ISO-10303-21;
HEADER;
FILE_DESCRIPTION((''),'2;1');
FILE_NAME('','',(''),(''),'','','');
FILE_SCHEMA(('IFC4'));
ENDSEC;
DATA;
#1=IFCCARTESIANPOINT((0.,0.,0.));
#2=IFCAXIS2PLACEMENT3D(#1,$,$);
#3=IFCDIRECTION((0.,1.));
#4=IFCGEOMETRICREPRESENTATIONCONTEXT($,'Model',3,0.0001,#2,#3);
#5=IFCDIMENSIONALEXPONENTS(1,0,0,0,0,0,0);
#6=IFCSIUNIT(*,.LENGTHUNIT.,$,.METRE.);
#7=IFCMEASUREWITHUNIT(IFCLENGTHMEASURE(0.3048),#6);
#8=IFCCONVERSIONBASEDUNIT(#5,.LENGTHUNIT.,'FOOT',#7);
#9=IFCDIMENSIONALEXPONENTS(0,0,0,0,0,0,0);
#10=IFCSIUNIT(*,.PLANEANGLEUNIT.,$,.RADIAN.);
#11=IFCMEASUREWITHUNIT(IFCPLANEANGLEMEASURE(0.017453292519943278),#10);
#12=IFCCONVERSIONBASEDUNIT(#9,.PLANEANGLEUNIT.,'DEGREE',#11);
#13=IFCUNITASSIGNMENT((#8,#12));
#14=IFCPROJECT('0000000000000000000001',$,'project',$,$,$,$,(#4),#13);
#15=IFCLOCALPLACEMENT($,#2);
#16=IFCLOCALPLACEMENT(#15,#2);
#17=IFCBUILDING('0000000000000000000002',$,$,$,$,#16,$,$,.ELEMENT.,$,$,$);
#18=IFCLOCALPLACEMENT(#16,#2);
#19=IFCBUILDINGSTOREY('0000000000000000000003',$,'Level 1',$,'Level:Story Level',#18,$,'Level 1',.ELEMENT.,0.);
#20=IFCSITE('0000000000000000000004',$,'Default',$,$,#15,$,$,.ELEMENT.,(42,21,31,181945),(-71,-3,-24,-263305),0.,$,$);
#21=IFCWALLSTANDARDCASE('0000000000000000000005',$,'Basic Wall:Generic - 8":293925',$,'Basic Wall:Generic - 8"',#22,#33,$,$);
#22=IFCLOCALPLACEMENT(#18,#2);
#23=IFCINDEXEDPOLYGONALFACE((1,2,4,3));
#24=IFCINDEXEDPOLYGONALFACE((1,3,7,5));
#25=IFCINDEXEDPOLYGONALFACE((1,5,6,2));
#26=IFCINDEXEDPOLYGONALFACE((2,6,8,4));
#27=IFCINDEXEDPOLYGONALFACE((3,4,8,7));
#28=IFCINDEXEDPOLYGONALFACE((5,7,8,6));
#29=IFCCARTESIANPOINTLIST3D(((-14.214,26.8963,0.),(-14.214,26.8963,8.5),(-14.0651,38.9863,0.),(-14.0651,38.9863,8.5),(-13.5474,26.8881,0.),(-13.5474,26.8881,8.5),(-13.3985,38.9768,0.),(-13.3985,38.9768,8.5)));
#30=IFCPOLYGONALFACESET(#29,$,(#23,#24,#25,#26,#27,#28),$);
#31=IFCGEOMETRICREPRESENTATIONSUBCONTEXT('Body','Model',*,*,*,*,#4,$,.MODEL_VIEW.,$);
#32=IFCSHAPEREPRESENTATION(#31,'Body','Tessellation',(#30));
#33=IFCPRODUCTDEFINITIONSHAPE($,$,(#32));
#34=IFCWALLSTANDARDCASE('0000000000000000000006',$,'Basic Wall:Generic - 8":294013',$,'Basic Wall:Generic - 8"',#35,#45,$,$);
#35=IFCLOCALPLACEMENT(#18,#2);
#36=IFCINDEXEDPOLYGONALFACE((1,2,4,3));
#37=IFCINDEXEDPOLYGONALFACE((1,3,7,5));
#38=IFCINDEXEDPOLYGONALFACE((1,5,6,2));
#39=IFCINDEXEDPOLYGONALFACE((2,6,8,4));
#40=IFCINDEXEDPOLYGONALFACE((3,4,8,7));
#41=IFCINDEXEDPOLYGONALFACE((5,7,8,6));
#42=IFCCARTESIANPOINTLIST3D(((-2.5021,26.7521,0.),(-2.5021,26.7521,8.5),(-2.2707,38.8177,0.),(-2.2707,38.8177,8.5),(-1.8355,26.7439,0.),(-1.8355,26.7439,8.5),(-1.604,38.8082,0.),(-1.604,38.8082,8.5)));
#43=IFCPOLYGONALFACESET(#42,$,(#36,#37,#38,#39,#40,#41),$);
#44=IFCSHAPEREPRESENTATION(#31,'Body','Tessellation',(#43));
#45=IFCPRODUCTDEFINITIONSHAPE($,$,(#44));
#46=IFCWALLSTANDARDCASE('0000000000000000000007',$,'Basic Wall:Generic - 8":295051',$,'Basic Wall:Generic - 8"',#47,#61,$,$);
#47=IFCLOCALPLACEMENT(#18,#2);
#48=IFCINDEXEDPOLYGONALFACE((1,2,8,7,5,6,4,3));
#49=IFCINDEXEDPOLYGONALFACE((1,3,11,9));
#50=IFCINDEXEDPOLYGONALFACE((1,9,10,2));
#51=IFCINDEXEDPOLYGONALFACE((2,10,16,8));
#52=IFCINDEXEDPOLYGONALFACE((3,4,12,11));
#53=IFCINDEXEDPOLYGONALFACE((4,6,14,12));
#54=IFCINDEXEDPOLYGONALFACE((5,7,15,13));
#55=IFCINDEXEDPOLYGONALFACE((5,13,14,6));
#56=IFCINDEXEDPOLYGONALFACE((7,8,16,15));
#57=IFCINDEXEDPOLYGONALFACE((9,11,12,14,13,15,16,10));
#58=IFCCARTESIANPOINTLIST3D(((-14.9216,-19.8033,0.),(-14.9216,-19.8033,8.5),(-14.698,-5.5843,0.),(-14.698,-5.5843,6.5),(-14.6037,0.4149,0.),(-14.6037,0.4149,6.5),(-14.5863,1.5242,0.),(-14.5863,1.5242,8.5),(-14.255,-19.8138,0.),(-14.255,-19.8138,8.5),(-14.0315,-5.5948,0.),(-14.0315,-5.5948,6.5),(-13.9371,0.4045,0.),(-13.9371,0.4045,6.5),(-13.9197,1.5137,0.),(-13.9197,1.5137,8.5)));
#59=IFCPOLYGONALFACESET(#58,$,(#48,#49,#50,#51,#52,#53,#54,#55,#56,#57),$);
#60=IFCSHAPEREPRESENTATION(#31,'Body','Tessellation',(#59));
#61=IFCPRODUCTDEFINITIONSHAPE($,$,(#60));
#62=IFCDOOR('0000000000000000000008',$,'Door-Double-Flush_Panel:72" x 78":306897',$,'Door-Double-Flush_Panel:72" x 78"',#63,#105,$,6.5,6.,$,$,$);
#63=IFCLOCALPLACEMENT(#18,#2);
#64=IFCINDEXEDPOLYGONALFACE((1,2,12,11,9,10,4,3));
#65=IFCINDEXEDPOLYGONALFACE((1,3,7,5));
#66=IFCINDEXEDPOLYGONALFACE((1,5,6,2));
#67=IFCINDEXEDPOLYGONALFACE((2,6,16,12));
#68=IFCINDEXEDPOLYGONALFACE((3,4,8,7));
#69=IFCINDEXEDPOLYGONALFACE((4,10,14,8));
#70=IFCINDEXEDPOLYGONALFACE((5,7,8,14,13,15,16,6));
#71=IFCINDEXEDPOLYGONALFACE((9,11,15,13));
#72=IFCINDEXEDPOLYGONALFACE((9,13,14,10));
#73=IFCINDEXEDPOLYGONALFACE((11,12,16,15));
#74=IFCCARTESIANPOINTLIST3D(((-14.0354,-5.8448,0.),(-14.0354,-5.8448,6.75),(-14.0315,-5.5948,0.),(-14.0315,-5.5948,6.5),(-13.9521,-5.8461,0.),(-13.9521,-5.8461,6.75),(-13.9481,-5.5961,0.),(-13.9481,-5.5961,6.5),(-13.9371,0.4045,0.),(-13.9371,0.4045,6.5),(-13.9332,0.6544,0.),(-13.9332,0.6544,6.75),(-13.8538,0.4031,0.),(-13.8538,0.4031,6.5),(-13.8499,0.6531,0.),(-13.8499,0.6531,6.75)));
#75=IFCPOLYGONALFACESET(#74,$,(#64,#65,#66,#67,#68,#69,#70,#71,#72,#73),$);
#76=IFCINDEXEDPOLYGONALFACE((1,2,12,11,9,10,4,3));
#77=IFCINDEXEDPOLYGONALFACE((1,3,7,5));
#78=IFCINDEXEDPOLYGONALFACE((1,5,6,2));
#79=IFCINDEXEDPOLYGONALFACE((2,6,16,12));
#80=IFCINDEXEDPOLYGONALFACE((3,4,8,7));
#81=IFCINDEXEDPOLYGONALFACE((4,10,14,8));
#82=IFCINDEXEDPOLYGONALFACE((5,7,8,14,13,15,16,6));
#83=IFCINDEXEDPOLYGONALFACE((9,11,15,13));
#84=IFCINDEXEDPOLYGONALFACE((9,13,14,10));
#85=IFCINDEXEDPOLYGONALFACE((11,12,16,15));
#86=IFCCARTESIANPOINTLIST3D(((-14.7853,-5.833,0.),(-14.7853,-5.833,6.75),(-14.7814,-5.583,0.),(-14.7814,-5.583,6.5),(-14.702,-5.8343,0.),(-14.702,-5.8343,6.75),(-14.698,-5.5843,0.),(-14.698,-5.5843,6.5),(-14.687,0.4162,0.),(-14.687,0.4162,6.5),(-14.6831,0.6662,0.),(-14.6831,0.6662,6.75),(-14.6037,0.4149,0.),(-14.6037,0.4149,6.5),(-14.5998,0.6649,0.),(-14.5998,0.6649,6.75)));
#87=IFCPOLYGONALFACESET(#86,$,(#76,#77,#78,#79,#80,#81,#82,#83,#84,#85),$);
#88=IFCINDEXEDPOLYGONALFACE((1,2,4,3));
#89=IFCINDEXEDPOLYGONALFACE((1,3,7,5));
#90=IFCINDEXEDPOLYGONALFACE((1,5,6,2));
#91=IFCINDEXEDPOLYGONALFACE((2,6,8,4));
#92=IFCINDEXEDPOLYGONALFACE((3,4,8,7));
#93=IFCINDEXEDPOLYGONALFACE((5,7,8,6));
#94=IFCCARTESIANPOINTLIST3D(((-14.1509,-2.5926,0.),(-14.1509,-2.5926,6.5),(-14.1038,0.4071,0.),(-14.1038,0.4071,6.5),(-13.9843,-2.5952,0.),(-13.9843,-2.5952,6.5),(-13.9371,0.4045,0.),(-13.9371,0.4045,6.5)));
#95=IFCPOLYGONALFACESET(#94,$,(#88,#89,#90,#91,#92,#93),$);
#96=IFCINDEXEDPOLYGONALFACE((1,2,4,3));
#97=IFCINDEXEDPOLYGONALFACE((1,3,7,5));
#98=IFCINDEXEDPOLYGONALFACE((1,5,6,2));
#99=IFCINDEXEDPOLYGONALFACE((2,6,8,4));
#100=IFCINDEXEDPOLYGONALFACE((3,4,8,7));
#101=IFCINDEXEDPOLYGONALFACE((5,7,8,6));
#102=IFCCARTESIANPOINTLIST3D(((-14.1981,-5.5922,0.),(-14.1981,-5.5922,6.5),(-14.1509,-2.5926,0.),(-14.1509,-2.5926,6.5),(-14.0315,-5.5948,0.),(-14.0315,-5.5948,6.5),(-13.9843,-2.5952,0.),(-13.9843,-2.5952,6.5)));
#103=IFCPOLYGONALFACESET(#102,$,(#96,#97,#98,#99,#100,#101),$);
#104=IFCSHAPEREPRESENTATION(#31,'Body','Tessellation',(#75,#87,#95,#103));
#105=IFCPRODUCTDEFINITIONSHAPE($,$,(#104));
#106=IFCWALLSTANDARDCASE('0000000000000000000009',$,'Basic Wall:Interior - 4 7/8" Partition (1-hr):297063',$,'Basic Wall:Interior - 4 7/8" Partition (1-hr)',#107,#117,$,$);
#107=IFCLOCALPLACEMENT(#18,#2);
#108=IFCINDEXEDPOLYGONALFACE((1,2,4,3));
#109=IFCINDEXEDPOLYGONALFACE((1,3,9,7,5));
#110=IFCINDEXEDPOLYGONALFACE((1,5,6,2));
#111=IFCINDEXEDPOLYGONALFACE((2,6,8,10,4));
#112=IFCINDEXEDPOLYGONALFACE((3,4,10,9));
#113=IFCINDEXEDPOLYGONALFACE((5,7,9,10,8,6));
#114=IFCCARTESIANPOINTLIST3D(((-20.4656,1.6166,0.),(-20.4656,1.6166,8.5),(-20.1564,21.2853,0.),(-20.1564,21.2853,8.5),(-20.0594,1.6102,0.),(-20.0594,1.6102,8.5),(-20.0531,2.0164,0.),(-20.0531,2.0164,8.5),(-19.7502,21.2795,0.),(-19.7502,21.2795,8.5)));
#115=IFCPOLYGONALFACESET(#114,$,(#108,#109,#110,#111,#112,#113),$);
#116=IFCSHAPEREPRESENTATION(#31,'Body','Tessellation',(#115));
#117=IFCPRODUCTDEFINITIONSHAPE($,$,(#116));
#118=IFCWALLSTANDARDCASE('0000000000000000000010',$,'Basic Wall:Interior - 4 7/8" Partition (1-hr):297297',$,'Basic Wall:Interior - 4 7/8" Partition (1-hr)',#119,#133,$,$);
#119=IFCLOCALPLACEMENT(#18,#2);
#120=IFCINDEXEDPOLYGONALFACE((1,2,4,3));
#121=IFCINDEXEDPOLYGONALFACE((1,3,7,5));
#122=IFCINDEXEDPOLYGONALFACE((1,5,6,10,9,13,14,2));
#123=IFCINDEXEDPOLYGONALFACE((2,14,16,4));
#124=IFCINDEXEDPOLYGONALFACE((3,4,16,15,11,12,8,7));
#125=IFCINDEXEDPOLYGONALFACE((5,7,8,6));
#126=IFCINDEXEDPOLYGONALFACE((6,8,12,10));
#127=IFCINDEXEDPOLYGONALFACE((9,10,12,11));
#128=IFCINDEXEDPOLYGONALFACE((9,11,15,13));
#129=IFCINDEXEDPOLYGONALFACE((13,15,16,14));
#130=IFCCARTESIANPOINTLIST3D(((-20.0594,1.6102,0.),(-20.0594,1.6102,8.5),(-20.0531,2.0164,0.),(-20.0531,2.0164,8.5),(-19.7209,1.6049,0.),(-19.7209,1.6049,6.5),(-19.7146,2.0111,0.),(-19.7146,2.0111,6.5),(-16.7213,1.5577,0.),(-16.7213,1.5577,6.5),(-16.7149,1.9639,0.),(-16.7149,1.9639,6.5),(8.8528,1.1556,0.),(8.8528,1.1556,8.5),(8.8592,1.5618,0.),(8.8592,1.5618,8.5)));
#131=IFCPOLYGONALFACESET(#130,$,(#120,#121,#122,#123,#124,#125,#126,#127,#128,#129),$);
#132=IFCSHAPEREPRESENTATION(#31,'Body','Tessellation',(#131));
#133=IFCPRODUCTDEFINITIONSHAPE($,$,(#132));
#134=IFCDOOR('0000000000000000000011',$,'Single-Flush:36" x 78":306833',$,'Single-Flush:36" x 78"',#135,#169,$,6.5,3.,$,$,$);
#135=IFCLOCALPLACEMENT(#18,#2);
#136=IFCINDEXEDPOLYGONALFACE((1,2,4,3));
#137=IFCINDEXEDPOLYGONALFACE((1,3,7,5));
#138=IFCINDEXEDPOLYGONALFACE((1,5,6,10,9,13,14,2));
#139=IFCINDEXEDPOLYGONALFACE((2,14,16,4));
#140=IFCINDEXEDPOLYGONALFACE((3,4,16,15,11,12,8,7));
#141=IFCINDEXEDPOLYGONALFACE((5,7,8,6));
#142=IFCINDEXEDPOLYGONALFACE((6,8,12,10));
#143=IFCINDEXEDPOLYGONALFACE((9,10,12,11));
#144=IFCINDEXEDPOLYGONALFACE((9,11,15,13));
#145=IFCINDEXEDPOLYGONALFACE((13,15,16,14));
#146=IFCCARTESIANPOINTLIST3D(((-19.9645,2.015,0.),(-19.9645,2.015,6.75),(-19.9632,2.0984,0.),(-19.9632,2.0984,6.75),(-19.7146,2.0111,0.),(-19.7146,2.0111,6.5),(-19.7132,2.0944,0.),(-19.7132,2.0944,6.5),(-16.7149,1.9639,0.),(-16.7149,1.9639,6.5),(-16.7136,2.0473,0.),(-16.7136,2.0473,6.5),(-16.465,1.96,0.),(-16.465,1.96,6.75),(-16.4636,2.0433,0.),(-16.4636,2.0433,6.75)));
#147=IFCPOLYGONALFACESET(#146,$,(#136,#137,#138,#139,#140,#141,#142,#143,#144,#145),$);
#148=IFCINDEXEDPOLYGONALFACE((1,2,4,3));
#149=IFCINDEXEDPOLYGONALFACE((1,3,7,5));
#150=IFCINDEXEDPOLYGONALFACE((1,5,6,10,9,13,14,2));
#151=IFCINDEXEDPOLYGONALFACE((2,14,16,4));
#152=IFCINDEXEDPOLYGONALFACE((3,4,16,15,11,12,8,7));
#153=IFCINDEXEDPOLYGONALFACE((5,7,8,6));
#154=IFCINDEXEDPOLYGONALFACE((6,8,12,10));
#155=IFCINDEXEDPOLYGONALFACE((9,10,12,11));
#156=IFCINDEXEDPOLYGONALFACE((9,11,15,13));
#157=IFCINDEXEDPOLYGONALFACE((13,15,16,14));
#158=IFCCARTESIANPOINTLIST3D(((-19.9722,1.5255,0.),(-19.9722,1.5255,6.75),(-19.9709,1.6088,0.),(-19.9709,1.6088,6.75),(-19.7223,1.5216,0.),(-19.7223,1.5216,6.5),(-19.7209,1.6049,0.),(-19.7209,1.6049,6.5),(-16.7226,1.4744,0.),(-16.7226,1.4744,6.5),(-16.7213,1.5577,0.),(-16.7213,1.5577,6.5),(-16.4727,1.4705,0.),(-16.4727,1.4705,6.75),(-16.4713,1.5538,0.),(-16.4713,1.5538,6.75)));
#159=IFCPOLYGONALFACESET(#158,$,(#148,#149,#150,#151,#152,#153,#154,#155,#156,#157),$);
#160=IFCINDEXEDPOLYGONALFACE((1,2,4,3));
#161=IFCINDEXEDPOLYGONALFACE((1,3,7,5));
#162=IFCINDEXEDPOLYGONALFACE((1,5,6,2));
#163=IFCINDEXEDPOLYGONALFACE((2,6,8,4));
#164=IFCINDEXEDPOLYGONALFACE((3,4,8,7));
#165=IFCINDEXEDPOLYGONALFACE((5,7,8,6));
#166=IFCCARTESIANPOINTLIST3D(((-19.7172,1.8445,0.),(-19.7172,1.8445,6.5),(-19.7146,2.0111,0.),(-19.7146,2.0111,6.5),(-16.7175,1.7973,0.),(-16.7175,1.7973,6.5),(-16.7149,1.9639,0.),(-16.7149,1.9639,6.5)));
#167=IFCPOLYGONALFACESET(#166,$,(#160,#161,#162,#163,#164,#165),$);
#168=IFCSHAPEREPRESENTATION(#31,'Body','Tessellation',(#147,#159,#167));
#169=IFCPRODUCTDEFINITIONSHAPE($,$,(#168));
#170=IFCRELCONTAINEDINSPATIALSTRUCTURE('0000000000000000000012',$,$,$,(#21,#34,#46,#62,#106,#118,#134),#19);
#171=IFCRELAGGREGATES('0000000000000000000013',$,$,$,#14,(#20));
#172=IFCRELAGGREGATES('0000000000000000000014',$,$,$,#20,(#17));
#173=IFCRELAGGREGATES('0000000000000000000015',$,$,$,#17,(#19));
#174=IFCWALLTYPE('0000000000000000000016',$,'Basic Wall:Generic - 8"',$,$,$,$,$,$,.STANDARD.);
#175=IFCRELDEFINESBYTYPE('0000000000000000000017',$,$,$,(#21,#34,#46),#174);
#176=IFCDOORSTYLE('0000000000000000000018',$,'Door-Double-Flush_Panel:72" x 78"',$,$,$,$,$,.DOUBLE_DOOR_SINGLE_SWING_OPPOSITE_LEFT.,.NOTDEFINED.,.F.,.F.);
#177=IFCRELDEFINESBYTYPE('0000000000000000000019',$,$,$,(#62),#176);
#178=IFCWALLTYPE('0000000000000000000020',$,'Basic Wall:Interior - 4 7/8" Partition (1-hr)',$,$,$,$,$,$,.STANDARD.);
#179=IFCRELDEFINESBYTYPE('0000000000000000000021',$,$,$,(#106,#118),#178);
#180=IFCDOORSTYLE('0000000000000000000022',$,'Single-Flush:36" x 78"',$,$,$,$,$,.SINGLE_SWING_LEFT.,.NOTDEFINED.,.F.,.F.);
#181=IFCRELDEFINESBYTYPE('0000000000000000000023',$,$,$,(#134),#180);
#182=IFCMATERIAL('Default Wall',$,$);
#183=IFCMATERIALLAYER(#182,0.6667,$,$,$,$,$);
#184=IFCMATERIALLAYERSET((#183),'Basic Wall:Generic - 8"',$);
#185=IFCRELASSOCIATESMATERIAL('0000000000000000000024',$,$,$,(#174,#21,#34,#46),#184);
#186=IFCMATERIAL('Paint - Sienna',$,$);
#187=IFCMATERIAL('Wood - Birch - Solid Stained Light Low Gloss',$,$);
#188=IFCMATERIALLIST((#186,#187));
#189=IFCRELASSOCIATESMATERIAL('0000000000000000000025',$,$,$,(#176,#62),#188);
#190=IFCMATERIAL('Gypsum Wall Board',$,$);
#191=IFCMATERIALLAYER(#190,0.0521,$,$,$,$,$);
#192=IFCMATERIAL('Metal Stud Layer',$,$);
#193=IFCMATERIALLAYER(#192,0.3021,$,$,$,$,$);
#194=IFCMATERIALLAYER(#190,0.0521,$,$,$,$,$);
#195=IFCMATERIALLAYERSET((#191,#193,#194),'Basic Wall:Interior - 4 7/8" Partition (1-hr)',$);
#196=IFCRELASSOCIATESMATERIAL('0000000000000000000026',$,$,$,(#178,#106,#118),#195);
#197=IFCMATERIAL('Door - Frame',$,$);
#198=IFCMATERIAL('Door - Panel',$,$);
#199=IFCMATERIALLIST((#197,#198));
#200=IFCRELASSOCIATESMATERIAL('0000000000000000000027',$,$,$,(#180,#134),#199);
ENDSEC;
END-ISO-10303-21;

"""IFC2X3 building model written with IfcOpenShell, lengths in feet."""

from ifc_helpers import new_model, entity, si_unit, converted_unit, direction, frame, frame_2d, origin, origin_2d_with_axis, place, context, subcontext, project, spatial, polyline, rectangle, outline, extrude, source, transform, mapped, material, material_list, layer, layer_set, layer_usage, type_object, type_shapes, element, fill, save


model = new_model("IFC2X3")

# Units and contexts
model_context = context("Model", 3, precision=0.0001, world=origin(), true_north=direction((0.0, 1.0)))
body_context = subcontext(model_context, "Body", "Model", "MODEL_VIEW")
ifc_project = project(units=[converted_unit("LENGTHUNIT", "FOOT", entity("IfcLengthMeasure", 0.3048), si_unit("LENGTHUNIT", "METRE"), dimensions=[1, 0, 0, 0, 0, 0, 0]), converted_unit("PLANEANGLEUNIT", "DEGREE", entity("IfcPlaneAngleMeasure", 0.017453292519943278), si_unit("PLANEANGLEUNIT", "RADIAN"), dimensions=[0, 0, 0, 0, 0, 0, 0])], contexts=[model_context])

# Site, building, storey
site_placement = place(None, origin())
site = spatial("IfcSite", under=ifc_project, at=site_placement, Name="Default", CompositionType="ELEMENT", RefLatitude=(42, 21, 31, 181945), RefLongitude=(-71, -3, -24, -263305), RefElevation=0.0)
building_placement = place(site_placement, origin())
building = spatial("IfcBuilding", under=site, at=building_placement, CompositionType="ELEMENT")
storey_placement = place(building_placement, origin())
storey = spatial("IfcBuildingStorey", under=building, at=storey_placement, Name="Level 1", ObjectType="Level:Story Level", LongName="Level 1", CompositionType="ELEMENT", Elevation=0.0)

# Shared definitions
ifc_material_1 = material(Name="Default Wall")
ifc_layer_1 = layer(ifc_material_1, 0.6667)
ifc_layer_set_1 = layer_set([ifc_layer_1], Name="Basic Wall:Generic - 8\"")
wall_type_1 = type_object("IfcWallType", Name="Basic Wall:Generic - 8\"", PredefinedType="STANDARD", material=ifc_layer_set_1)

# Walls
ifc_layer_usage_1 = layer_usage(ifc_layer_set_1, "AXIS2", "NEGATIVE", 0.3333)
wall_1_placement = place(storey_placement, frame((-13.7318, 38.9822, 0.0), z_axis=(0.0, 0.0, 1.0), x_axis=(-0.012316, -0.999924, 0.0)))
element("IfcWallStandardCase", 1, at=wall_1_placement, inside=storey, type_object=wall_type_1, material=ifc_layer_usage_1, Name="Basic Wall:Generic - 8\":293925", ObjectType="Basic Wall:Generic - 8\"", context=body_context, shape_type="SweptSolid", body=[
    extrude(outline(polyline([(12.0909, -0.3333), (12.0909, 0.3333), (0.0013, 0.3333), (0.0, -0.3333), (12.0909, -0.3333)])), origin(), (0.0, 0.0, 1.0), 8.5),
])
ifc_layer_usage_2 = layer_usage(ifc_layer_set_1, "AXIS2", "NEGATIVE", 0.3333)
wall_2_placement = place(storey_placement, frame((-1.9373, 38.8146, 0.0), z_axis=(0.0, 0.0, 1.0), x_axis=(-0.019177, -0.999816, 0.0)))
element("IfcWallStandardCase", 2, at=wall_2_placement, inside=storey, type_object=wall_type_1, material=ifc_layer_usage_2, Name="Basic Wall:Generic - 8\":294013", ObjectType="Basic Wall:Generic - 8\"", context=body_context, shape_type="SweptSolid", body=[
    extrude(outline(polyline([(12.0711, -0.3333), (12.0666, 0.3333), (0.0, 0.3333), (0.0033, -0.3333), (12.0711, -0.3333)])), origin(), (0.0, 0.0, 1.0), 8.5),
])

# Wall, opening, door
ifc_layer_usage_3 = layer_usage(ifc_layer_set_1, "AXIS2", "NEGATIVE", 0.3333)
wall_3_placement = place(storey_placement, frame((-14.253, 1.5189, 0.0), z_axis=(0.0, 0.0, 1.0), x_axis=(-0.015721, -0.999876, 0.0)))
wall_3 = element("IfcWallStandardCase", 3, at=wall_3_placement, inside=storey, type_object=wall_type_1, material=ifc_layer_usage_3, Name="Basic Wall:Generic - 8\":295051", ObjectType="Basic Wall:Generic - 8\"", context=body_context, shape_type="SweptSolid", body=[
    extrude(rectangle(XDim=21.3301, YDim=0.6667, at=frame_2d((10.665, 0.0), x_axis=(-1.0, 0.0))), origin(), (0.0, 0.0, 1.0), 8.5),
])
opening_1_placement = place(wall_3_placement, frame((1.1094, -0.3333, 0.0)))
opening_1 = element("IfcOpeningElement", 4, at=opening_1_placement, cuts=wall_3, ObjectType="Opening", context=body_context, shape_type="SweptSolid", body=[
    extrude(rectangle(XDim=6.5, YDim=6.0, at=frame_2d((3.25, 3.0), x_axis=(1.0, 0.0))), frame((0.0, 0.0, 0.0), z_axis=(0.0, 1.0, 0.0), x_axis=(0.0, 0.0, 1.0)), (0.0, 0.0, 1.0), 0.6667),
])
ifc_material_2 = material(Name="Paint - Sienna")
ifc_material_3 = material(Name="Wood - Birch - Solid Stained Light Low Gloss")
ifc_material_list_1 = material_list([ifc_material_2, ifc_material_3])
door_style_1 = type_object("IfcDoorStyle", Name="Door-Double-Flush_Panel:72\" x 78\"", ConstructionType="NOTDEFINED", OperationType="DOUBLE_DOOR_SINGLE_SWING_OPPOSITE_LEFT", ParameterTakesPrecedence=False, Sizeable=False, material=ifc_material_list_1)
shared_shape_1 = source(origin(), body_context, "Body", "SweptSolid", [
    extrude(outline(polyline([(-3.1875, 3.0), (3.3125, 3.0), (3.3125, 3.25), (-3.4375, 3.25), (-3.4375, -3.25), (3.3125, -3.25), (3.3125, -3.0), (-3.1875, -3.0), (-3.1875, 3.0)])), frame((3.0, 0.6667, 3.3125), z_axis=(0.0, 1.0, 0.0), x_axis=(0.0, 0.0, -1.0)), (0.0, 0.0, 1.0), 0.0833),
    extrude(outline(polyline([(-3.1875, 3.0), (3.3125, 3.0), (3.3125, 3.25), (-3.4375, 3.25), (-3.4375, -3.25), (3.3125, -3.25), (3.3125, -3.0), (-3.1875, -3.0), (-3.1875, 3.0)])), frame((3.0, -0.0833, 3.3125), z_axis=(0.0, 1.0, 0.0), x_axis=(0.0, 0.0, -1.0)), (0.0, 0.0, 1.0), 0.0833),
    extrude(rectangle(XDim=0.1667, YDim=3.0, at=frame_2d((0.0, 0.0), x_axis=(1.0, 0.0))), frame((1.5, 0.5833, 0.0), z_axis=(0.0, 0.0, 1.0), x_axis=(0.0, -1.0, 0.0)), (0.0, 0.0, 1.0), 6.5),
    extrude(rectangle(XDim=0.1667, YDim=3.0, at=frame_2d((0.0, 0.0), x_axis=(1.0, 0.0))), frame((4.5, 0.5833, 0.0), z_axis=(0.0, 0.0, 1.0), x_axis=(0.0, -1.0, 0.0)), (0.0, 0.0, 1.0), 6.5),
])
type_shapes(door_style_1, [shared_shape_1])
door_1_placement = place(opening_1_placement, origin())
door_1 = element("IfcDoor", 5, at=door_1_placement, inside=storey, type_object=door_style_1, material=ifc_material_list_1, Name="Door-Double-Flush_Panel:72\" x 78\":306897", ObjectType="Door-Double-Flush_Panel:72\" x 78\"", OverallHeight=6.5, OverallWidth=6.0, context=body_context, shape_type="MappedRepresentation", body=[
    mapped(shared_shape_1, transform((0.0, 0.0, 0.0), scale=1.0)),
])
fill(opening_1, door_1)

# Wall
ifc_material_4 = material(Name="Gypsum Wall Board")
ifc_layer_2 = layer(ifc_material_4, 0.0521)
ifc_material_5 = material(Name="Metal Stud Layer")
ifc_layer_3 = layer(ifc_material_5, 0.3021)
ifc_layer_4 = layer(ifc_material_4, 0.0521)
ifc_layer_set_2 = layer_set([ifc_layer_2, ifc_layer_3, ifc_layer_4], Name="Basic Wall:Interior - 4 7/8\" Partition (1-hr)")
ifc_layer_usage_4 = layer_usage(ifc_layer_set_2, "AXIS2", "NEGATIVE", 0.2031)
wall_type_2 = type_object("IfcWallType", Name="Basic Wall:Interior - 4 7/8\" Partition (1-hr)", PredefinedType="STANDARD", material=ifc_layer_set_2)
wall_4_placement = place(storey_placement, frame((-19.9533, 21.2827, 0.0), z_axis=(0.0, 0.0, 1.0), x_axis=(-0.015721, -0.999876, 0.0)))
element("IfcWallStandardCase", 6, at=wall_4_placement, inside=storey, type_object=wall_type_2, material=ifc_layer_usage_4, Name="Basic Wall:Interior - 4 7/8\" Partition (1-hr):297063", ObjectType="Basic Wall:Interior - 4 7/8\" Partition (1-hr)", context=body_context, shape_type="SweptSolid", body=[
    extrude(outline(polyline([(19.6717, -0.2031), (19.6717, 0.2031), (19.2655, 0.2031), (0.0, 0.2031), (0.0006, -0.2031), (19.6717, -0.2031)])), origin(), (0.0, 0.0, 1.0), 8.5),
])

# Wall, opening, door
ifc_layer_usage_5 = layer_usage(ifc_layer_set_2, "AXIS2", "NEGATIVE", 0.2031)
wall_5_placement = place(storey_placement, frame((-20.0563, 1.8133, 0.0), z_axis=(0.0, 0.0, 1.0), x_axis=(0.999876, -0.015721, 0.0)))
wall_5 = element("IfcWallStandardCase", 7, at=wall_5_placement, inside=storey, type_object=wall_type_2, material=ifc_layer_usage_5, Name="Basic Wall:Interior - 4 7/8\" Partition (1-hr):297297", ObjectType="Basic Wall:Interior - 4 7/8\" Partition (1-hr)", context=body_context, shape_type="SweptSolid", body=[
    extrude(rectangle(XDim=28.9158, YDim=0.4063, at=frame_2d((14.4579, 0.0), x_axis=(1.0, 0.0))), origin(), (0.0, 0.0, 1.0), 8.5),
])
opening_2_placement = place(wall_5_placement, frame((0.3385, -0.2031, 0.0)))
opening_2 = element("IfcOpeningElement", 8, at=opening_2_placement, cuts=wall_5, ObjectType="Opening", context=body_context, shape_type="SweptSolid", body=[
    extrude(rectangle(XDim=3.0, YDim=6.5, at=frame_2d((3.25, 1.5), x_axis=(0.0, -1.0))), frame((0.0, 0.0, 0.0), z_axis=(0.0, 1.0, 0.0), x_axis=(0.0, 0.0, 1.0)), (0.0, 0.0, 1.0), 0.4062),
])
ifc_material_6 = material(Name="Door - Frame")
ifc_material_7 = material(Name="Door - Panel")
ifc_material_list_2 = material_list([ifc_material_6, ifc_material_7])
door_style_2 = type_object("IfcDoorStyle", Name="Single-Flush:36\" x 78\"", ConstructionType="NOTDEFINED", OperationType="SINGLE_SWING_LEFT", ParameterTakesPrecedence=False, Sizeable=False, material=ifc_material_list_2)
shared_shape_2 = source(origin(), body_context, "Body", "SweptSolid", [
    extrude(outline(polyline([(-1.75, -3.4375), (1.75, -3.4375), (1.75, 3.3125), (1.5, 3.3125), (1.5, -3.1875), (-1.5, -3.1875), (-1.5, 3.3125), (-1.75, 3.3125), (-1.75, -3.4375)])), frame((1.5, 0.4896, 3.3125), z_axis=(0.0, -1.0, 0.0), x_axis=(-1.0, 0.0, 0.0)), (0.0, 0.0, 1.0), 0.0833),
    extrude(outline(polyline([(-3.4375, -1.75), (3.3125, -1.75), (3.3125, -1.5), (-3.1875, -1.5), (-3.1875, 1.5), (3.3125, 1.5), (3.3125, 1.75), (-3.4375, 1.75), (-3.4375, -1.75)])), frame((1.5, 0.0, 3.3125), z_axis=(0.0, -1.0, 0.0), x_axis=(0.0, 0.0, -1.0)), (0.0, 0.0, 1.0), 0.0833),
    extrude(rectangle(XDim=3.0, YDim=0.1667, at=origin_2d_with_axis()), frame((1.5, 0.3229, 0.0)), (0.0, 0.0, 1.0), 6.5),
])
type_shapes(door_style_2, [shared_shape_2])
door_2_placement = place(opening_2_placement, origin())
door_2 = element("IfcDoor", 9, at=door_2_placement, inside=storey, type_object=door_style_2, material=ifc_material_list_2, Name="Single-Flush:36\" x 78\":306833", ObjectType="Single-Flush:36\" x 78\"", OverallHeight=6.5, OverallWidth=3.0, context=body_context, shape_type="MappedRepresentation", body=[
    mapped(shared_shape_2, transform((0.0, 0.0, 0.0), scale=1.0)),
])
fill(opening_2, door_2)

save(model, "model.ifc")
